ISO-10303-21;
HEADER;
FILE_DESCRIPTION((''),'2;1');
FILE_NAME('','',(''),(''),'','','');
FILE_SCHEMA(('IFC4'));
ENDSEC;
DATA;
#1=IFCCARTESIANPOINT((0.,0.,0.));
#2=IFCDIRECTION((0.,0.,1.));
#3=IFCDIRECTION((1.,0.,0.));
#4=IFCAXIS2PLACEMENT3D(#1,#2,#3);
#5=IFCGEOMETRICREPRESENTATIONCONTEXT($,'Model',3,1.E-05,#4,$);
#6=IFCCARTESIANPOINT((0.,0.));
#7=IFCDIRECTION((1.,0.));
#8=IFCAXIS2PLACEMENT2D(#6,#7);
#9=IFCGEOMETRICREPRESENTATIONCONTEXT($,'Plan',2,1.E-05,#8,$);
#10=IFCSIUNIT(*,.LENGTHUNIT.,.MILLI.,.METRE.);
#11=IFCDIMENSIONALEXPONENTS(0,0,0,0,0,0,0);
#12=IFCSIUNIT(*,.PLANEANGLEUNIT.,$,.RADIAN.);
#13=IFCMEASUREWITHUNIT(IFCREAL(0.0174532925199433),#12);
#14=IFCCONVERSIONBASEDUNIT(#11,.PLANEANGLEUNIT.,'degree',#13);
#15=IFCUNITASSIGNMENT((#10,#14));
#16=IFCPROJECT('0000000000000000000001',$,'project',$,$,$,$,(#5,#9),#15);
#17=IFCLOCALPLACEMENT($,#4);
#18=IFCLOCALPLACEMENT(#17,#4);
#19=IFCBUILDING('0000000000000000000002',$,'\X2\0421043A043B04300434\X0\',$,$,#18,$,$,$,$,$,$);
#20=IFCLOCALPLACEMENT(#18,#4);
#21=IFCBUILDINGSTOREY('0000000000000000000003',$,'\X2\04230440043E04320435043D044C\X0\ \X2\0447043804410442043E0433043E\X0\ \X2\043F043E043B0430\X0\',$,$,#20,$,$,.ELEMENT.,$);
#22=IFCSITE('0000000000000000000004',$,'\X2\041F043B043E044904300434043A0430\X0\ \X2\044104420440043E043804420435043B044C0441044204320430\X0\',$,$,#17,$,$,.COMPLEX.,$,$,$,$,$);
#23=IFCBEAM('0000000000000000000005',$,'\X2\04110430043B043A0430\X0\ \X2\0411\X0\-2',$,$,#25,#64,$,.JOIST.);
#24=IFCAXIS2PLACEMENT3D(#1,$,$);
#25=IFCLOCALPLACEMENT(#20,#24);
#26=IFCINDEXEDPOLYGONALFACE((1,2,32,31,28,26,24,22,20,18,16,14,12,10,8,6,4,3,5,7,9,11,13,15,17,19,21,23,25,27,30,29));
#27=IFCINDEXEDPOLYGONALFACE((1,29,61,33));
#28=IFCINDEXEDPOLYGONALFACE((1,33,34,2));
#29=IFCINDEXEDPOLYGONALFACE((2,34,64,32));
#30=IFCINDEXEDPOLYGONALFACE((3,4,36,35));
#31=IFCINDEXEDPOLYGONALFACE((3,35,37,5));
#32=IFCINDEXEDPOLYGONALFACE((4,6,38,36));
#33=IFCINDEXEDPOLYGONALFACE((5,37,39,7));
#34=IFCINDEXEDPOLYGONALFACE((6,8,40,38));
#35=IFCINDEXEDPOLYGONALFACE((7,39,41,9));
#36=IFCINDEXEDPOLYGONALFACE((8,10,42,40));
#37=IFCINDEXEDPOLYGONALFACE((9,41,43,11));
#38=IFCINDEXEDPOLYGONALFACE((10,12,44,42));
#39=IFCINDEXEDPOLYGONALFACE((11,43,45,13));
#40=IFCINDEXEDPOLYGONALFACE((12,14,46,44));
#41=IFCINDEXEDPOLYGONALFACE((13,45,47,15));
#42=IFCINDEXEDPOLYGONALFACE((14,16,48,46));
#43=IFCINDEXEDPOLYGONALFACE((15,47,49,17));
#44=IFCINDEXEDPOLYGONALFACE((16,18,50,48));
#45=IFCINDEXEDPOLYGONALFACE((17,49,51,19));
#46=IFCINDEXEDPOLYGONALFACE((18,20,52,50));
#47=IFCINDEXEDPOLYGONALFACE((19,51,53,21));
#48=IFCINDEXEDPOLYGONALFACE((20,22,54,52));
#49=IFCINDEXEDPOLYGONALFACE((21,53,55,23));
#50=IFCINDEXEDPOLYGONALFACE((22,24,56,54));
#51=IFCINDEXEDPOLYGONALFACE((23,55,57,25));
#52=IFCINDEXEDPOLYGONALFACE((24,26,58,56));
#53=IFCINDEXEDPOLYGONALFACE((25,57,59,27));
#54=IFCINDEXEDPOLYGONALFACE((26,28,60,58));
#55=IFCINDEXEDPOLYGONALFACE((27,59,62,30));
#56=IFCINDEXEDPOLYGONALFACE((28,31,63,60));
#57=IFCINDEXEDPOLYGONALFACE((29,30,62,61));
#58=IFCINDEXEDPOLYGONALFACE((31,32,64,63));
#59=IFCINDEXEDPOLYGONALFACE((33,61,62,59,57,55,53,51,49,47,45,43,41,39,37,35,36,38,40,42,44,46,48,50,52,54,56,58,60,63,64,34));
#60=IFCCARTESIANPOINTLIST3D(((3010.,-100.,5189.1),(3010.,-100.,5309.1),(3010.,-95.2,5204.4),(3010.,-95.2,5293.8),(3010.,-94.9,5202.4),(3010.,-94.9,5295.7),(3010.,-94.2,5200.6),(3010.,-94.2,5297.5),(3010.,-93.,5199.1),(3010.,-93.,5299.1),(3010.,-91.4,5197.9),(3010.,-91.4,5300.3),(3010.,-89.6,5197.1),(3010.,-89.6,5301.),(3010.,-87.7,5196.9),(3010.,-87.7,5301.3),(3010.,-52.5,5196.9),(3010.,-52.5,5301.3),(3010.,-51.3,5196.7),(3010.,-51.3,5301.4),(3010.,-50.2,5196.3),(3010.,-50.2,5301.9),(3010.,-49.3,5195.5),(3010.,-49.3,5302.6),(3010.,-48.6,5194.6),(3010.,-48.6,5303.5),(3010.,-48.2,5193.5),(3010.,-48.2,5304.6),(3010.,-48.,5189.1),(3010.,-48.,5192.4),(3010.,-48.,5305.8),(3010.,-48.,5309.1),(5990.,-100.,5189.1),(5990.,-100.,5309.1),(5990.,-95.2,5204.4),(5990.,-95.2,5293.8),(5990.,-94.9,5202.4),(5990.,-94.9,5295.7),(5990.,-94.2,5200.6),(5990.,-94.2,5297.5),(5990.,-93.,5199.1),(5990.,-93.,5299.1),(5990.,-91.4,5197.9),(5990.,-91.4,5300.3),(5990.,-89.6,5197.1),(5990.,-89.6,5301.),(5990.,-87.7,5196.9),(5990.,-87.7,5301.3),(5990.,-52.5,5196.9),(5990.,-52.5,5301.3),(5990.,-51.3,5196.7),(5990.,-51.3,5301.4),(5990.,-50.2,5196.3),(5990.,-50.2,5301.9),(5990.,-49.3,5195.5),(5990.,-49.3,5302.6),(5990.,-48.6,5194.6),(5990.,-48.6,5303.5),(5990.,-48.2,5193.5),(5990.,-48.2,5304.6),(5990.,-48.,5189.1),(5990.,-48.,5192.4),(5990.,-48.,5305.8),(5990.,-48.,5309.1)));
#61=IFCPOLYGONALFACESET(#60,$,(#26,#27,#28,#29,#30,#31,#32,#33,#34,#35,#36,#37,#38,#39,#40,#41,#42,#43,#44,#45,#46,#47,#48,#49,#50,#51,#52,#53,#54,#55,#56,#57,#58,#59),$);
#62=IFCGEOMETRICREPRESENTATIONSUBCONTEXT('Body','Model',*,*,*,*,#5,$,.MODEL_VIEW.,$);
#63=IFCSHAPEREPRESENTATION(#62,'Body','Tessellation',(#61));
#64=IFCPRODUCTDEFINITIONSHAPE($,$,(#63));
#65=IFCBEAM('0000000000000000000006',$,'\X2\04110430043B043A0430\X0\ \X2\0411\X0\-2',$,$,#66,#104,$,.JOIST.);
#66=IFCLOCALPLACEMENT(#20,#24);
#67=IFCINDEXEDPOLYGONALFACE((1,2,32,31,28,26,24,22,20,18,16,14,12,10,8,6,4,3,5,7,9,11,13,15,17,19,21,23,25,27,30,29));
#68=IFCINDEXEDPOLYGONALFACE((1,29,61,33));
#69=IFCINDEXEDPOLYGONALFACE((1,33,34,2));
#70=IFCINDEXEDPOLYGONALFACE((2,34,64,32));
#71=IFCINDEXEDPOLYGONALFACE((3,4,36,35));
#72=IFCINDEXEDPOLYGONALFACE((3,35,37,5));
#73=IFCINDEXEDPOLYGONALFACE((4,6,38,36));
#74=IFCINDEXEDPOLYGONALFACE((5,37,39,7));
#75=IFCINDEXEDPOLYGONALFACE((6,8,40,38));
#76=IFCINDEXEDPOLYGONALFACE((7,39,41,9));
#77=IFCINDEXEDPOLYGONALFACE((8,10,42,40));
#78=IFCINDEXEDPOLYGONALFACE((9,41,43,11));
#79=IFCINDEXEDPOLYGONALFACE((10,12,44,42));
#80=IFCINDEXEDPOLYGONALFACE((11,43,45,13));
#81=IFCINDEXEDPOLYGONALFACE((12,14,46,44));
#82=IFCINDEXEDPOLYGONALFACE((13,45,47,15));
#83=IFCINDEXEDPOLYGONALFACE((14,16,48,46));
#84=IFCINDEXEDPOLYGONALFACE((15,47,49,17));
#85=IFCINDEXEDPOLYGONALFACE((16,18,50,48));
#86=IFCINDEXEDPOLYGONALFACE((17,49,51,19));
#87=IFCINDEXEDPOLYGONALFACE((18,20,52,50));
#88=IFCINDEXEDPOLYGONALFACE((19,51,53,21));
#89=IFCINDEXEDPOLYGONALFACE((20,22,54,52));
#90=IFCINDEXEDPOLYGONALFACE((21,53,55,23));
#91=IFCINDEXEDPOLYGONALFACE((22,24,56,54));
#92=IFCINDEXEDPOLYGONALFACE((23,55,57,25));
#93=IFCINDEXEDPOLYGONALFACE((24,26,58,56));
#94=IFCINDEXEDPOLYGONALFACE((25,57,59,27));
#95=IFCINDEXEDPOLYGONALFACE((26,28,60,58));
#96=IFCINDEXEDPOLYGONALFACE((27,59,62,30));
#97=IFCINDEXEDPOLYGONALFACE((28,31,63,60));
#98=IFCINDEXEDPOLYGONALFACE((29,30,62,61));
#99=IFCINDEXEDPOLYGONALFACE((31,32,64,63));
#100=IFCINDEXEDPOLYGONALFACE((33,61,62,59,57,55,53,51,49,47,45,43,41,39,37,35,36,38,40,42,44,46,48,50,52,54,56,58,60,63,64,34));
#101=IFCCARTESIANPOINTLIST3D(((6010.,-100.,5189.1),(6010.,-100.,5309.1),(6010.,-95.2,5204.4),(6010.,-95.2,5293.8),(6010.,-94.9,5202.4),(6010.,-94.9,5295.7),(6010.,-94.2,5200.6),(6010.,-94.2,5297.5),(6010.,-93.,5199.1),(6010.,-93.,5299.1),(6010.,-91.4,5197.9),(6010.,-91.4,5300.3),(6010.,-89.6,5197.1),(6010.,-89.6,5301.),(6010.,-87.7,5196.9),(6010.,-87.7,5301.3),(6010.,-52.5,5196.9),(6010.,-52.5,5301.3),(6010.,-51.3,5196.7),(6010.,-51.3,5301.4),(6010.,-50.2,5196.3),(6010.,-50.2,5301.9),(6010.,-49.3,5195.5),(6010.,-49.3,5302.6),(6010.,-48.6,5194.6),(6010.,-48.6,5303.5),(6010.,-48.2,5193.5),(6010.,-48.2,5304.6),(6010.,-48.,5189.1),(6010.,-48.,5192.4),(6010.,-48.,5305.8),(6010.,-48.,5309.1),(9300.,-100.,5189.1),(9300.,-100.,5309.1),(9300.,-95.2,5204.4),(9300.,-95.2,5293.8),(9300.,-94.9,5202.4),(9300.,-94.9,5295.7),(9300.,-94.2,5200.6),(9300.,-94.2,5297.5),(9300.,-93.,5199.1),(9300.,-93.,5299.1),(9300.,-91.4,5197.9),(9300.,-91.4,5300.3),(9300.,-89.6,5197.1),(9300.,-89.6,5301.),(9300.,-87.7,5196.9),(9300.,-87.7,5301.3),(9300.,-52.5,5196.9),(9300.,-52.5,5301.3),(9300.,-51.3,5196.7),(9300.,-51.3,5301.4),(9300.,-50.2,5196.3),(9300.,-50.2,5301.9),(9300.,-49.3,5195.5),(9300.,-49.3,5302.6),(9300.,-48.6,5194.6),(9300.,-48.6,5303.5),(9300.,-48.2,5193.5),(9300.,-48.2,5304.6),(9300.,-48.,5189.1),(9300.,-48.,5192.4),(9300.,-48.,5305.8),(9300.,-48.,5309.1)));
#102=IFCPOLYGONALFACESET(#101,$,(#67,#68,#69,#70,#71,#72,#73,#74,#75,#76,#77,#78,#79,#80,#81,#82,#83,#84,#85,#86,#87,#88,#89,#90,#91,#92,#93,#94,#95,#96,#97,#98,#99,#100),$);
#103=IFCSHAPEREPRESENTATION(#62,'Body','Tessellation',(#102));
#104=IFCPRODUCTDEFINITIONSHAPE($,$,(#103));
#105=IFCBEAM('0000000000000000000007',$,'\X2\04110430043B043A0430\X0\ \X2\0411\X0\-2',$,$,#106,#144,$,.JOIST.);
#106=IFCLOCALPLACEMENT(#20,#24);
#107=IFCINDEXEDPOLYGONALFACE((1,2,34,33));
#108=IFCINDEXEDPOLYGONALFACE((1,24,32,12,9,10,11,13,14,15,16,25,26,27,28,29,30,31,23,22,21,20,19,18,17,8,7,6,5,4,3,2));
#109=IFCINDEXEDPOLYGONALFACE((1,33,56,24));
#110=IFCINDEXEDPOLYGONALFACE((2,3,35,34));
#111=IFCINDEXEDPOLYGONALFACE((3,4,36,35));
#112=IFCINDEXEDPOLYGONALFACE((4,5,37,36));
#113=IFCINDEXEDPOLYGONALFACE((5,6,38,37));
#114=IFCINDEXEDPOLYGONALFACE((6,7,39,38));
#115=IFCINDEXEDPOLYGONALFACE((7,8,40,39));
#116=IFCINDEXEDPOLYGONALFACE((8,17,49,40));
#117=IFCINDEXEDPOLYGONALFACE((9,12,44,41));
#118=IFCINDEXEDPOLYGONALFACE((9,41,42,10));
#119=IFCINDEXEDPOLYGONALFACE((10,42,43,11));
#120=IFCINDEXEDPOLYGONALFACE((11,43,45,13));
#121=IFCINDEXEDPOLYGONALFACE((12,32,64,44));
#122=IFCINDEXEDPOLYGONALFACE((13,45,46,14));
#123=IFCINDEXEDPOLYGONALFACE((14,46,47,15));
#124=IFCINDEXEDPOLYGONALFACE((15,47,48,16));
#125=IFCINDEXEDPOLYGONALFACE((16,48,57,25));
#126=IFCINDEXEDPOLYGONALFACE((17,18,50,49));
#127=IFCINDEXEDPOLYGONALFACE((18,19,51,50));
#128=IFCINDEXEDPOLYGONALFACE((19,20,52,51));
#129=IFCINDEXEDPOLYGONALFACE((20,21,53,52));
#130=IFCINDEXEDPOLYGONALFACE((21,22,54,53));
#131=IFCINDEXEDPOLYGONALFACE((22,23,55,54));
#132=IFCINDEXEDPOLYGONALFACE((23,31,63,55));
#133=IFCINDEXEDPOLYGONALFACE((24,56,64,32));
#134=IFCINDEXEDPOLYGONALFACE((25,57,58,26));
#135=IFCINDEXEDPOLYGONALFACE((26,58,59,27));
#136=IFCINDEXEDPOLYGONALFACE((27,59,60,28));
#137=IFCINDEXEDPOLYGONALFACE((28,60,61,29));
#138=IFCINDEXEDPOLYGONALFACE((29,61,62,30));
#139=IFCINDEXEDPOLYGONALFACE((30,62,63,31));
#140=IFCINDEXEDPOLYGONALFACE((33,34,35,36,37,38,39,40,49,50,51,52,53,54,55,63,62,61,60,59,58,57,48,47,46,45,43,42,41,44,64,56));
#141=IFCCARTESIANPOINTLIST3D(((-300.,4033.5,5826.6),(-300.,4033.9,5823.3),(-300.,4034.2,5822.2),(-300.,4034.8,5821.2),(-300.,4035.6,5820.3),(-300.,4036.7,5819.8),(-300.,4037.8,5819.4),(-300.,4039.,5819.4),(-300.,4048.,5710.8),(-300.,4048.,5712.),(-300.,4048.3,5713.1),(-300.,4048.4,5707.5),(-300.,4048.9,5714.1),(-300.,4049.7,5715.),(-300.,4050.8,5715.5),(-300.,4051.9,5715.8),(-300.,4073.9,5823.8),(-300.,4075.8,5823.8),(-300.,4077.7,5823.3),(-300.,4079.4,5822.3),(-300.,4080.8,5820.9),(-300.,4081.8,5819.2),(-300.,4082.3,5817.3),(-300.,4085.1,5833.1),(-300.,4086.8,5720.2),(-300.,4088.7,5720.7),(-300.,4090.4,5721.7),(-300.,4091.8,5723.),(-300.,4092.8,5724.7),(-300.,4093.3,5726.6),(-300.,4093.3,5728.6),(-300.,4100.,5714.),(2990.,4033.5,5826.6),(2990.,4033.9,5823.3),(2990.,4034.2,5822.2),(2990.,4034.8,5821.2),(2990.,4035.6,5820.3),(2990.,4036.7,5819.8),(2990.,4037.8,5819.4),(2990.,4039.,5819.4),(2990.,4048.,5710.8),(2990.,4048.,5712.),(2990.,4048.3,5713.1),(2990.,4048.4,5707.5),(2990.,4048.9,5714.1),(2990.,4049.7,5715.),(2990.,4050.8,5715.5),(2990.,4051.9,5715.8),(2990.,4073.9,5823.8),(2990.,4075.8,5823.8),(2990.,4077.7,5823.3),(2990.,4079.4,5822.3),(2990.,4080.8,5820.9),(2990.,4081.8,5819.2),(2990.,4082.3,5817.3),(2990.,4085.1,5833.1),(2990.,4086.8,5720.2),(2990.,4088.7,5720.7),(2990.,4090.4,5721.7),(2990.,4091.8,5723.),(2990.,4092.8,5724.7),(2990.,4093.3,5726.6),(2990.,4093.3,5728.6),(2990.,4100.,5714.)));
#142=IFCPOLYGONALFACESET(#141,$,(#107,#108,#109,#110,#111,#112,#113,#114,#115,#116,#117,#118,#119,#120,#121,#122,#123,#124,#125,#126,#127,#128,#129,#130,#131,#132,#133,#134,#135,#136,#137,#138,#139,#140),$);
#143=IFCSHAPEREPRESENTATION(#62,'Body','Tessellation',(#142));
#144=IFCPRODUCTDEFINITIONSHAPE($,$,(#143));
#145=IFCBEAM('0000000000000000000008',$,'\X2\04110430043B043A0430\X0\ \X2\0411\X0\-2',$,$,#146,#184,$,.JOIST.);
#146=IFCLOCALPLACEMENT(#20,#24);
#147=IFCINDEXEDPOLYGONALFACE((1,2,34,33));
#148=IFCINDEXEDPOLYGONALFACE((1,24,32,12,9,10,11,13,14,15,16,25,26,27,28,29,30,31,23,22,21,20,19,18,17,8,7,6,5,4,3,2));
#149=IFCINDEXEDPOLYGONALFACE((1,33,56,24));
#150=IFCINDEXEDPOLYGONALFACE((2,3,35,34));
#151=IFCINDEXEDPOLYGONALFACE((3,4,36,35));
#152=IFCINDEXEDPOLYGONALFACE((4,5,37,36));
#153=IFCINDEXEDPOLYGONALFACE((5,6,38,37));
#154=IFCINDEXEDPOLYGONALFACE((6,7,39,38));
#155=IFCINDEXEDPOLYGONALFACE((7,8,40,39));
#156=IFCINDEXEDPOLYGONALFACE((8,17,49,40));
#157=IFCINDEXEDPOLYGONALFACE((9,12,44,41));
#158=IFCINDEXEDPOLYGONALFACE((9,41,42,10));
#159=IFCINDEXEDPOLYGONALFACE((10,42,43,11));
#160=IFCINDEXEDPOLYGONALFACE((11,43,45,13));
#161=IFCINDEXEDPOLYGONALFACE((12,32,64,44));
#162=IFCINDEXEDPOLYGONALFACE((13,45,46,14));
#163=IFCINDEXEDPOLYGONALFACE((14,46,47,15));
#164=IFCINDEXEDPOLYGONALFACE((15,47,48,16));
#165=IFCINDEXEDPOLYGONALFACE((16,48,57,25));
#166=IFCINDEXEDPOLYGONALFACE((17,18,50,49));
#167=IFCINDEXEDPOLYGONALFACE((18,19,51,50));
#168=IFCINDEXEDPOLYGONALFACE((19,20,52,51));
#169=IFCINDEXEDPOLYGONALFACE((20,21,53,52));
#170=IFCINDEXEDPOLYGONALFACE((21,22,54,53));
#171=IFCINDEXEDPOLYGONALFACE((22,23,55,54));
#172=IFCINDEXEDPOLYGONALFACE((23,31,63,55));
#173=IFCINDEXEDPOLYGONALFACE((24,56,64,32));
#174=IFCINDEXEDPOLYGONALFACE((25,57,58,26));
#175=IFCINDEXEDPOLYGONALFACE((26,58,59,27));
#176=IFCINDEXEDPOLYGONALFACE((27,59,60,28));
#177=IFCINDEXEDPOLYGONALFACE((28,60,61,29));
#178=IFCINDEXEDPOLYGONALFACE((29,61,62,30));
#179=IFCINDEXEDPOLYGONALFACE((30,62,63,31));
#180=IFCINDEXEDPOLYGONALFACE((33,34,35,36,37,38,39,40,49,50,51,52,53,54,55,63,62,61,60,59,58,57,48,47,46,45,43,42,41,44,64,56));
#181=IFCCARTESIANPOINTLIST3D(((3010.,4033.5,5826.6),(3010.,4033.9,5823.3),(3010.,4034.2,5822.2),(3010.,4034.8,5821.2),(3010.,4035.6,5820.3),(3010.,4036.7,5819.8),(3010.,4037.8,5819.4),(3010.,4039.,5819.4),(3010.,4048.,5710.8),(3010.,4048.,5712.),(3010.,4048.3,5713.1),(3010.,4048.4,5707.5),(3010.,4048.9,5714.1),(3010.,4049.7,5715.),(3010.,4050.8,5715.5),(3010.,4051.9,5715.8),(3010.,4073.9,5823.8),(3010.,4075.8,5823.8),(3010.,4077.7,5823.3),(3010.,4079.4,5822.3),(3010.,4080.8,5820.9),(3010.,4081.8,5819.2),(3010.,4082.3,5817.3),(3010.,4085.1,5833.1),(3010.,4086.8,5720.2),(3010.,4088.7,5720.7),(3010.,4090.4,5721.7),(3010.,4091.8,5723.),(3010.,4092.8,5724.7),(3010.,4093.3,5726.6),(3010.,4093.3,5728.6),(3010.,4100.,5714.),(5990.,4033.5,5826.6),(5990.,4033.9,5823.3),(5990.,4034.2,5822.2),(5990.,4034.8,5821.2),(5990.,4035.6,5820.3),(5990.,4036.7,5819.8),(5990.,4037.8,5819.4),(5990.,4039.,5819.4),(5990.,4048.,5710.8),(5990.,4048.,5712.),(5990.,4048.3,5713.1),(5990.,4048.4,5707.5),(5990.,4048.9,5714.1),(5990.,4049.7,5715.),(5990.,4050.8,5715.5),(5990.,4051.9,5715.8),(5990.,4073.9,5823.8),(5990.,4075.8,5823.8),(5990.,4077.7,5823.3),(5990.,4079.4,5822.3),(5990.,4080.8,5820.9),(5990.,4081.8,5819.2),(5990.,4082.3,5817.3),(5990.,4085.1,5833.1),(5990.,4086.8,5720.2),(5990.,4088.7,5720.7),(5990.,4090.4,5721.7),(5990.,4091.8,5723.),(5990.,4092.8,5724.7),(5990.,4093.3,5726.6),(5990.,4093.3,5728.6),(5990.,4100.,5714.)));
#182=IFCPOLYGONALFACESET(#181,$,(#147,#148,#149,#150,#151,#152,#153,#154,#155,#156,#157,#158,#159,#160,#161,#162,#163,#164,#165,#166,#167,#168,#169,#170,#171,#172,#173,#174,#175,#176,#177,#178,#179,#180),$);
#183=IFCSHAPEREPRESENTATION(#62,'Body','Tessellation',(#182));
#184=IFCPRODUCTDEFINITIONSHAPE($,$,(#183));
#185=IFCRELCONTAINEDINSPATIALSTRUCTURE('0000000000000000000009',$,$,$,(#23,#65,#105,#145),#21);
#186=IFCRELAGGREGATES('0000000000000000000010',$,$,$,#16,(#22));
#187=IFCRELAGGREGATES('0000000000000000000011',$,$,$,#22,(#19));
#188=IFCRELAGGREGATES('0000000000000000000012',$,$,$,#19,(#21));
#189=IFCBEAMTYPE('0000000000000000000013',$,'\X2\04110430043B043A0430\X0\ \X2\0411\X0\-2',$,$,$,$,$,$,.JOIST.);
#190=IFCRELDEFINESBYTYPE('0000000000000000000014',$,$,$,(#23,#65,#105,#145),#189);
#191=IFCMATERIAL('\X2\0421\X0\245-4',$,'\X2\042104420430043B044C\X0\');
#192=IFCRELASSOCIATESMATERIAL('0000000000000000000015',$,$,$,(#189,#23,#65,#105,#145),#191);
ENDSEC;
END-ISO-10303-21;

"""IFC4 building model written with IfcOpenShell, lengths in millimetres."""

from ifc_helpers import new_model, entity, si_unit, converted_unit, frame, origin_with_axes, origin_2d_with_axis, place, context, subcontext, project, spatial, u_section, extrude, material, material_profile, profile_set, profile_usage, type_object, element, save


model = new_model("IFC4")

# Units and contexts
model_context = context("Model", 3, precision=1e-05, world=origin_with_axes())
plan_context = context("Plan", 2, precision=1e-05, world=origin_2d_with_axis())
body_context = subcontext(model_context, "Body", "Model", "MODEL_VIEW")
ifc_project = project(units=[si_unit("LENGTHUNIT", "METRE", prefix="MILLI"), converted_unit("PLANEANGLEUNIT", "degree", entity("IfcReal", 0.0174532925199433), si_unit("PLANEANGLEUNIT", "RADIAN"), dimensions=[0, 0, 0, 0, 0, 0, 0])], contexts=[model_context, plan_context])

# Site, building, storey
site_placement = place(None, origin_with_axes())
site = spatial("IfcSite", under=ifc_project, at=site_placement, Name="Площадка строительства", CompositionType="COMPLEX")
building_placement = place(site_placement, origin_with_axes())
building = spatial("IfcBuilding", under=site, at=building_placement, Name="Склад")
storey_placement = place(building_placement, origin_with_axes())
storey = spatial("IfcBuildingStorey", under=building, at=storey_placement, Name="Уровень чистого пола", CompositionType="ELEMENT")

# Beams
ifc_material_1 = material(Name="С245-4", Category="Сталь")
ifc_material_profile_1 = material_profile(ifc_material_1, u_section(Depth=120.0, FlangeWidth=52.0, WebThickness=4.8, FlangeThickness=7.8, FilletRadius=7.5, EdgeRadius=4.5, FlangeSlope=0.0))
ifc_profile_set_1 = profile_set([ifc_material_profile_1], Name="U12P_S245-4")
beam_type_1 = type_object("IfcBeamType", Name="Балка Б-2", PredefinedType="JOIST", material=ifc_profile_set_1)
ifc_profile_usage_1 = profile_usage(ifc_profile_set_1, cardinal=3)
beam_1_placement = place(storey_placement, frame((3010.0, -100.0, 5189.1), z_axis=(1.0, 0.0, 0.0), x_axis=(0.0, 1.0, 0.0)))
element("IfcBeam", 1, at=beam_1_placement, inside=storey, type_object=beam_type_1, material=ifc_profile_usage_1, Name="Балка Б-2", PredefinedType="JOIST", context=body_context, shape_type="SweptSolid", body=[
    extrude(u_section(Depth=120.0, FlangeWidth=52.0, WebThickness=4.8, FlangeThickness=7.8, FilletRadius=7.5, EdgeRadius=4.5, FlangeSlope=0.0), frame((26.0, 60.0, 0.0), z_axis=(0.0, 0.0, 1.0), x_axis=(1.0, 0.0, 0.0)), (0.0, 0.0, 1.0), 2980.0),
])
ifc_profile_usage_2 = profile_usage(ifc_profile_set_1, cardinal=3)
beam_2_placement = place(storey_placement, frame((6010.0, -100.0, 5189.1), z_axis=(1.0, 0.0, 0.0), x_axis=(0.0, 1.0, 0.0)))
element("IfcBeam", 2, at=beam_2_placement, inside=storey, type_object=beam_type_1, material=ifc_profile_usage_2, Name="Балка Б-2", PredefinedType="JOIST", context=body_context, shape_type="SweptSolid", body=[
    extrude(u_section(Depth=120.0, FlangeWidth=52.0, WebThickness=4.8, FlangeThickness=7.8, FilletRadius=7.5, EdgeRadius=4.5, FlangeSlope=0.0), frame((26.0, 60.0, 0.0), z_axis=(0.0, 0.0, 1.0), x_axis=(1.0, 0.0, 0.0)), (0.0, 0.0, 1.0), 3290.0),
])
ifc_profile_usage_3 = profile_usage(ifc_profile_set_1, cardinal=3)
beam_3_placement = place(storey_placement, frame((2990.0, 4100.0, 5714.0), z_axis=(-1.0, 0.0, 0.0), x_axis=(0.0, -0.99228, -0.124019)))
element("IfcBeam", 3, at=beam_3_placement, inside=storey, type_object=beam_type_1, material=ifc_profile_usage_3, Name="Балка Б-2", PredefinedType="JOIST", context=body_context, shape_type="SweptSolid", body=[
    extrude(u_section(Depth=120.0, FlangeWidth=52.0, WebThickness=4.8, FlangeThickness=7.8, FilletRadius=7.5, EdgeRadius=4.5, FlangeSlope=0.0), frame((26.0, 60.0, 0.0), z_axis=(0.0, 0.0, 1.0), x_axis=(1.0, 0.0, 0.0)), (0.0, 0.0, 1.0), 3290.0),
])
ifc_profile_usage_4 = profile_usage(ifc_profile_set_1, cardinal=3)
beam_4_placement = place(storey_placement, frame((5990.0, 4100.0, 5714.0), z_axis=(-1.0, 0.0, 0.0), x_axis=(0.0, -0.99228, -0.12402)))
element("IfcBeam", 4, at=beam_4_placement, inside=storey, type_object=beam_type_1, material=ifc_profile_usage_4, Name="Балка Б-2", PredefinedType="JOIST", context=body_context, shape_type="SweptSolid", body=[
    extrude(u_section(Depth=120.0, FlangeWidth=52.0, WebThickness=4.8, FlangeThickness=7.8, FilletRadius=7.5, EdgeRadius=4.5, FlangeSlope=0.0), frame((26.0, 60.0, 0.0), z_axis=(0.0, 0.0, 1.0), x_axis=(1.0, 0.0, 0.0)), (0.0, 0.0, 1.0), 2980.0),
])

save(model, "model.ifc")
